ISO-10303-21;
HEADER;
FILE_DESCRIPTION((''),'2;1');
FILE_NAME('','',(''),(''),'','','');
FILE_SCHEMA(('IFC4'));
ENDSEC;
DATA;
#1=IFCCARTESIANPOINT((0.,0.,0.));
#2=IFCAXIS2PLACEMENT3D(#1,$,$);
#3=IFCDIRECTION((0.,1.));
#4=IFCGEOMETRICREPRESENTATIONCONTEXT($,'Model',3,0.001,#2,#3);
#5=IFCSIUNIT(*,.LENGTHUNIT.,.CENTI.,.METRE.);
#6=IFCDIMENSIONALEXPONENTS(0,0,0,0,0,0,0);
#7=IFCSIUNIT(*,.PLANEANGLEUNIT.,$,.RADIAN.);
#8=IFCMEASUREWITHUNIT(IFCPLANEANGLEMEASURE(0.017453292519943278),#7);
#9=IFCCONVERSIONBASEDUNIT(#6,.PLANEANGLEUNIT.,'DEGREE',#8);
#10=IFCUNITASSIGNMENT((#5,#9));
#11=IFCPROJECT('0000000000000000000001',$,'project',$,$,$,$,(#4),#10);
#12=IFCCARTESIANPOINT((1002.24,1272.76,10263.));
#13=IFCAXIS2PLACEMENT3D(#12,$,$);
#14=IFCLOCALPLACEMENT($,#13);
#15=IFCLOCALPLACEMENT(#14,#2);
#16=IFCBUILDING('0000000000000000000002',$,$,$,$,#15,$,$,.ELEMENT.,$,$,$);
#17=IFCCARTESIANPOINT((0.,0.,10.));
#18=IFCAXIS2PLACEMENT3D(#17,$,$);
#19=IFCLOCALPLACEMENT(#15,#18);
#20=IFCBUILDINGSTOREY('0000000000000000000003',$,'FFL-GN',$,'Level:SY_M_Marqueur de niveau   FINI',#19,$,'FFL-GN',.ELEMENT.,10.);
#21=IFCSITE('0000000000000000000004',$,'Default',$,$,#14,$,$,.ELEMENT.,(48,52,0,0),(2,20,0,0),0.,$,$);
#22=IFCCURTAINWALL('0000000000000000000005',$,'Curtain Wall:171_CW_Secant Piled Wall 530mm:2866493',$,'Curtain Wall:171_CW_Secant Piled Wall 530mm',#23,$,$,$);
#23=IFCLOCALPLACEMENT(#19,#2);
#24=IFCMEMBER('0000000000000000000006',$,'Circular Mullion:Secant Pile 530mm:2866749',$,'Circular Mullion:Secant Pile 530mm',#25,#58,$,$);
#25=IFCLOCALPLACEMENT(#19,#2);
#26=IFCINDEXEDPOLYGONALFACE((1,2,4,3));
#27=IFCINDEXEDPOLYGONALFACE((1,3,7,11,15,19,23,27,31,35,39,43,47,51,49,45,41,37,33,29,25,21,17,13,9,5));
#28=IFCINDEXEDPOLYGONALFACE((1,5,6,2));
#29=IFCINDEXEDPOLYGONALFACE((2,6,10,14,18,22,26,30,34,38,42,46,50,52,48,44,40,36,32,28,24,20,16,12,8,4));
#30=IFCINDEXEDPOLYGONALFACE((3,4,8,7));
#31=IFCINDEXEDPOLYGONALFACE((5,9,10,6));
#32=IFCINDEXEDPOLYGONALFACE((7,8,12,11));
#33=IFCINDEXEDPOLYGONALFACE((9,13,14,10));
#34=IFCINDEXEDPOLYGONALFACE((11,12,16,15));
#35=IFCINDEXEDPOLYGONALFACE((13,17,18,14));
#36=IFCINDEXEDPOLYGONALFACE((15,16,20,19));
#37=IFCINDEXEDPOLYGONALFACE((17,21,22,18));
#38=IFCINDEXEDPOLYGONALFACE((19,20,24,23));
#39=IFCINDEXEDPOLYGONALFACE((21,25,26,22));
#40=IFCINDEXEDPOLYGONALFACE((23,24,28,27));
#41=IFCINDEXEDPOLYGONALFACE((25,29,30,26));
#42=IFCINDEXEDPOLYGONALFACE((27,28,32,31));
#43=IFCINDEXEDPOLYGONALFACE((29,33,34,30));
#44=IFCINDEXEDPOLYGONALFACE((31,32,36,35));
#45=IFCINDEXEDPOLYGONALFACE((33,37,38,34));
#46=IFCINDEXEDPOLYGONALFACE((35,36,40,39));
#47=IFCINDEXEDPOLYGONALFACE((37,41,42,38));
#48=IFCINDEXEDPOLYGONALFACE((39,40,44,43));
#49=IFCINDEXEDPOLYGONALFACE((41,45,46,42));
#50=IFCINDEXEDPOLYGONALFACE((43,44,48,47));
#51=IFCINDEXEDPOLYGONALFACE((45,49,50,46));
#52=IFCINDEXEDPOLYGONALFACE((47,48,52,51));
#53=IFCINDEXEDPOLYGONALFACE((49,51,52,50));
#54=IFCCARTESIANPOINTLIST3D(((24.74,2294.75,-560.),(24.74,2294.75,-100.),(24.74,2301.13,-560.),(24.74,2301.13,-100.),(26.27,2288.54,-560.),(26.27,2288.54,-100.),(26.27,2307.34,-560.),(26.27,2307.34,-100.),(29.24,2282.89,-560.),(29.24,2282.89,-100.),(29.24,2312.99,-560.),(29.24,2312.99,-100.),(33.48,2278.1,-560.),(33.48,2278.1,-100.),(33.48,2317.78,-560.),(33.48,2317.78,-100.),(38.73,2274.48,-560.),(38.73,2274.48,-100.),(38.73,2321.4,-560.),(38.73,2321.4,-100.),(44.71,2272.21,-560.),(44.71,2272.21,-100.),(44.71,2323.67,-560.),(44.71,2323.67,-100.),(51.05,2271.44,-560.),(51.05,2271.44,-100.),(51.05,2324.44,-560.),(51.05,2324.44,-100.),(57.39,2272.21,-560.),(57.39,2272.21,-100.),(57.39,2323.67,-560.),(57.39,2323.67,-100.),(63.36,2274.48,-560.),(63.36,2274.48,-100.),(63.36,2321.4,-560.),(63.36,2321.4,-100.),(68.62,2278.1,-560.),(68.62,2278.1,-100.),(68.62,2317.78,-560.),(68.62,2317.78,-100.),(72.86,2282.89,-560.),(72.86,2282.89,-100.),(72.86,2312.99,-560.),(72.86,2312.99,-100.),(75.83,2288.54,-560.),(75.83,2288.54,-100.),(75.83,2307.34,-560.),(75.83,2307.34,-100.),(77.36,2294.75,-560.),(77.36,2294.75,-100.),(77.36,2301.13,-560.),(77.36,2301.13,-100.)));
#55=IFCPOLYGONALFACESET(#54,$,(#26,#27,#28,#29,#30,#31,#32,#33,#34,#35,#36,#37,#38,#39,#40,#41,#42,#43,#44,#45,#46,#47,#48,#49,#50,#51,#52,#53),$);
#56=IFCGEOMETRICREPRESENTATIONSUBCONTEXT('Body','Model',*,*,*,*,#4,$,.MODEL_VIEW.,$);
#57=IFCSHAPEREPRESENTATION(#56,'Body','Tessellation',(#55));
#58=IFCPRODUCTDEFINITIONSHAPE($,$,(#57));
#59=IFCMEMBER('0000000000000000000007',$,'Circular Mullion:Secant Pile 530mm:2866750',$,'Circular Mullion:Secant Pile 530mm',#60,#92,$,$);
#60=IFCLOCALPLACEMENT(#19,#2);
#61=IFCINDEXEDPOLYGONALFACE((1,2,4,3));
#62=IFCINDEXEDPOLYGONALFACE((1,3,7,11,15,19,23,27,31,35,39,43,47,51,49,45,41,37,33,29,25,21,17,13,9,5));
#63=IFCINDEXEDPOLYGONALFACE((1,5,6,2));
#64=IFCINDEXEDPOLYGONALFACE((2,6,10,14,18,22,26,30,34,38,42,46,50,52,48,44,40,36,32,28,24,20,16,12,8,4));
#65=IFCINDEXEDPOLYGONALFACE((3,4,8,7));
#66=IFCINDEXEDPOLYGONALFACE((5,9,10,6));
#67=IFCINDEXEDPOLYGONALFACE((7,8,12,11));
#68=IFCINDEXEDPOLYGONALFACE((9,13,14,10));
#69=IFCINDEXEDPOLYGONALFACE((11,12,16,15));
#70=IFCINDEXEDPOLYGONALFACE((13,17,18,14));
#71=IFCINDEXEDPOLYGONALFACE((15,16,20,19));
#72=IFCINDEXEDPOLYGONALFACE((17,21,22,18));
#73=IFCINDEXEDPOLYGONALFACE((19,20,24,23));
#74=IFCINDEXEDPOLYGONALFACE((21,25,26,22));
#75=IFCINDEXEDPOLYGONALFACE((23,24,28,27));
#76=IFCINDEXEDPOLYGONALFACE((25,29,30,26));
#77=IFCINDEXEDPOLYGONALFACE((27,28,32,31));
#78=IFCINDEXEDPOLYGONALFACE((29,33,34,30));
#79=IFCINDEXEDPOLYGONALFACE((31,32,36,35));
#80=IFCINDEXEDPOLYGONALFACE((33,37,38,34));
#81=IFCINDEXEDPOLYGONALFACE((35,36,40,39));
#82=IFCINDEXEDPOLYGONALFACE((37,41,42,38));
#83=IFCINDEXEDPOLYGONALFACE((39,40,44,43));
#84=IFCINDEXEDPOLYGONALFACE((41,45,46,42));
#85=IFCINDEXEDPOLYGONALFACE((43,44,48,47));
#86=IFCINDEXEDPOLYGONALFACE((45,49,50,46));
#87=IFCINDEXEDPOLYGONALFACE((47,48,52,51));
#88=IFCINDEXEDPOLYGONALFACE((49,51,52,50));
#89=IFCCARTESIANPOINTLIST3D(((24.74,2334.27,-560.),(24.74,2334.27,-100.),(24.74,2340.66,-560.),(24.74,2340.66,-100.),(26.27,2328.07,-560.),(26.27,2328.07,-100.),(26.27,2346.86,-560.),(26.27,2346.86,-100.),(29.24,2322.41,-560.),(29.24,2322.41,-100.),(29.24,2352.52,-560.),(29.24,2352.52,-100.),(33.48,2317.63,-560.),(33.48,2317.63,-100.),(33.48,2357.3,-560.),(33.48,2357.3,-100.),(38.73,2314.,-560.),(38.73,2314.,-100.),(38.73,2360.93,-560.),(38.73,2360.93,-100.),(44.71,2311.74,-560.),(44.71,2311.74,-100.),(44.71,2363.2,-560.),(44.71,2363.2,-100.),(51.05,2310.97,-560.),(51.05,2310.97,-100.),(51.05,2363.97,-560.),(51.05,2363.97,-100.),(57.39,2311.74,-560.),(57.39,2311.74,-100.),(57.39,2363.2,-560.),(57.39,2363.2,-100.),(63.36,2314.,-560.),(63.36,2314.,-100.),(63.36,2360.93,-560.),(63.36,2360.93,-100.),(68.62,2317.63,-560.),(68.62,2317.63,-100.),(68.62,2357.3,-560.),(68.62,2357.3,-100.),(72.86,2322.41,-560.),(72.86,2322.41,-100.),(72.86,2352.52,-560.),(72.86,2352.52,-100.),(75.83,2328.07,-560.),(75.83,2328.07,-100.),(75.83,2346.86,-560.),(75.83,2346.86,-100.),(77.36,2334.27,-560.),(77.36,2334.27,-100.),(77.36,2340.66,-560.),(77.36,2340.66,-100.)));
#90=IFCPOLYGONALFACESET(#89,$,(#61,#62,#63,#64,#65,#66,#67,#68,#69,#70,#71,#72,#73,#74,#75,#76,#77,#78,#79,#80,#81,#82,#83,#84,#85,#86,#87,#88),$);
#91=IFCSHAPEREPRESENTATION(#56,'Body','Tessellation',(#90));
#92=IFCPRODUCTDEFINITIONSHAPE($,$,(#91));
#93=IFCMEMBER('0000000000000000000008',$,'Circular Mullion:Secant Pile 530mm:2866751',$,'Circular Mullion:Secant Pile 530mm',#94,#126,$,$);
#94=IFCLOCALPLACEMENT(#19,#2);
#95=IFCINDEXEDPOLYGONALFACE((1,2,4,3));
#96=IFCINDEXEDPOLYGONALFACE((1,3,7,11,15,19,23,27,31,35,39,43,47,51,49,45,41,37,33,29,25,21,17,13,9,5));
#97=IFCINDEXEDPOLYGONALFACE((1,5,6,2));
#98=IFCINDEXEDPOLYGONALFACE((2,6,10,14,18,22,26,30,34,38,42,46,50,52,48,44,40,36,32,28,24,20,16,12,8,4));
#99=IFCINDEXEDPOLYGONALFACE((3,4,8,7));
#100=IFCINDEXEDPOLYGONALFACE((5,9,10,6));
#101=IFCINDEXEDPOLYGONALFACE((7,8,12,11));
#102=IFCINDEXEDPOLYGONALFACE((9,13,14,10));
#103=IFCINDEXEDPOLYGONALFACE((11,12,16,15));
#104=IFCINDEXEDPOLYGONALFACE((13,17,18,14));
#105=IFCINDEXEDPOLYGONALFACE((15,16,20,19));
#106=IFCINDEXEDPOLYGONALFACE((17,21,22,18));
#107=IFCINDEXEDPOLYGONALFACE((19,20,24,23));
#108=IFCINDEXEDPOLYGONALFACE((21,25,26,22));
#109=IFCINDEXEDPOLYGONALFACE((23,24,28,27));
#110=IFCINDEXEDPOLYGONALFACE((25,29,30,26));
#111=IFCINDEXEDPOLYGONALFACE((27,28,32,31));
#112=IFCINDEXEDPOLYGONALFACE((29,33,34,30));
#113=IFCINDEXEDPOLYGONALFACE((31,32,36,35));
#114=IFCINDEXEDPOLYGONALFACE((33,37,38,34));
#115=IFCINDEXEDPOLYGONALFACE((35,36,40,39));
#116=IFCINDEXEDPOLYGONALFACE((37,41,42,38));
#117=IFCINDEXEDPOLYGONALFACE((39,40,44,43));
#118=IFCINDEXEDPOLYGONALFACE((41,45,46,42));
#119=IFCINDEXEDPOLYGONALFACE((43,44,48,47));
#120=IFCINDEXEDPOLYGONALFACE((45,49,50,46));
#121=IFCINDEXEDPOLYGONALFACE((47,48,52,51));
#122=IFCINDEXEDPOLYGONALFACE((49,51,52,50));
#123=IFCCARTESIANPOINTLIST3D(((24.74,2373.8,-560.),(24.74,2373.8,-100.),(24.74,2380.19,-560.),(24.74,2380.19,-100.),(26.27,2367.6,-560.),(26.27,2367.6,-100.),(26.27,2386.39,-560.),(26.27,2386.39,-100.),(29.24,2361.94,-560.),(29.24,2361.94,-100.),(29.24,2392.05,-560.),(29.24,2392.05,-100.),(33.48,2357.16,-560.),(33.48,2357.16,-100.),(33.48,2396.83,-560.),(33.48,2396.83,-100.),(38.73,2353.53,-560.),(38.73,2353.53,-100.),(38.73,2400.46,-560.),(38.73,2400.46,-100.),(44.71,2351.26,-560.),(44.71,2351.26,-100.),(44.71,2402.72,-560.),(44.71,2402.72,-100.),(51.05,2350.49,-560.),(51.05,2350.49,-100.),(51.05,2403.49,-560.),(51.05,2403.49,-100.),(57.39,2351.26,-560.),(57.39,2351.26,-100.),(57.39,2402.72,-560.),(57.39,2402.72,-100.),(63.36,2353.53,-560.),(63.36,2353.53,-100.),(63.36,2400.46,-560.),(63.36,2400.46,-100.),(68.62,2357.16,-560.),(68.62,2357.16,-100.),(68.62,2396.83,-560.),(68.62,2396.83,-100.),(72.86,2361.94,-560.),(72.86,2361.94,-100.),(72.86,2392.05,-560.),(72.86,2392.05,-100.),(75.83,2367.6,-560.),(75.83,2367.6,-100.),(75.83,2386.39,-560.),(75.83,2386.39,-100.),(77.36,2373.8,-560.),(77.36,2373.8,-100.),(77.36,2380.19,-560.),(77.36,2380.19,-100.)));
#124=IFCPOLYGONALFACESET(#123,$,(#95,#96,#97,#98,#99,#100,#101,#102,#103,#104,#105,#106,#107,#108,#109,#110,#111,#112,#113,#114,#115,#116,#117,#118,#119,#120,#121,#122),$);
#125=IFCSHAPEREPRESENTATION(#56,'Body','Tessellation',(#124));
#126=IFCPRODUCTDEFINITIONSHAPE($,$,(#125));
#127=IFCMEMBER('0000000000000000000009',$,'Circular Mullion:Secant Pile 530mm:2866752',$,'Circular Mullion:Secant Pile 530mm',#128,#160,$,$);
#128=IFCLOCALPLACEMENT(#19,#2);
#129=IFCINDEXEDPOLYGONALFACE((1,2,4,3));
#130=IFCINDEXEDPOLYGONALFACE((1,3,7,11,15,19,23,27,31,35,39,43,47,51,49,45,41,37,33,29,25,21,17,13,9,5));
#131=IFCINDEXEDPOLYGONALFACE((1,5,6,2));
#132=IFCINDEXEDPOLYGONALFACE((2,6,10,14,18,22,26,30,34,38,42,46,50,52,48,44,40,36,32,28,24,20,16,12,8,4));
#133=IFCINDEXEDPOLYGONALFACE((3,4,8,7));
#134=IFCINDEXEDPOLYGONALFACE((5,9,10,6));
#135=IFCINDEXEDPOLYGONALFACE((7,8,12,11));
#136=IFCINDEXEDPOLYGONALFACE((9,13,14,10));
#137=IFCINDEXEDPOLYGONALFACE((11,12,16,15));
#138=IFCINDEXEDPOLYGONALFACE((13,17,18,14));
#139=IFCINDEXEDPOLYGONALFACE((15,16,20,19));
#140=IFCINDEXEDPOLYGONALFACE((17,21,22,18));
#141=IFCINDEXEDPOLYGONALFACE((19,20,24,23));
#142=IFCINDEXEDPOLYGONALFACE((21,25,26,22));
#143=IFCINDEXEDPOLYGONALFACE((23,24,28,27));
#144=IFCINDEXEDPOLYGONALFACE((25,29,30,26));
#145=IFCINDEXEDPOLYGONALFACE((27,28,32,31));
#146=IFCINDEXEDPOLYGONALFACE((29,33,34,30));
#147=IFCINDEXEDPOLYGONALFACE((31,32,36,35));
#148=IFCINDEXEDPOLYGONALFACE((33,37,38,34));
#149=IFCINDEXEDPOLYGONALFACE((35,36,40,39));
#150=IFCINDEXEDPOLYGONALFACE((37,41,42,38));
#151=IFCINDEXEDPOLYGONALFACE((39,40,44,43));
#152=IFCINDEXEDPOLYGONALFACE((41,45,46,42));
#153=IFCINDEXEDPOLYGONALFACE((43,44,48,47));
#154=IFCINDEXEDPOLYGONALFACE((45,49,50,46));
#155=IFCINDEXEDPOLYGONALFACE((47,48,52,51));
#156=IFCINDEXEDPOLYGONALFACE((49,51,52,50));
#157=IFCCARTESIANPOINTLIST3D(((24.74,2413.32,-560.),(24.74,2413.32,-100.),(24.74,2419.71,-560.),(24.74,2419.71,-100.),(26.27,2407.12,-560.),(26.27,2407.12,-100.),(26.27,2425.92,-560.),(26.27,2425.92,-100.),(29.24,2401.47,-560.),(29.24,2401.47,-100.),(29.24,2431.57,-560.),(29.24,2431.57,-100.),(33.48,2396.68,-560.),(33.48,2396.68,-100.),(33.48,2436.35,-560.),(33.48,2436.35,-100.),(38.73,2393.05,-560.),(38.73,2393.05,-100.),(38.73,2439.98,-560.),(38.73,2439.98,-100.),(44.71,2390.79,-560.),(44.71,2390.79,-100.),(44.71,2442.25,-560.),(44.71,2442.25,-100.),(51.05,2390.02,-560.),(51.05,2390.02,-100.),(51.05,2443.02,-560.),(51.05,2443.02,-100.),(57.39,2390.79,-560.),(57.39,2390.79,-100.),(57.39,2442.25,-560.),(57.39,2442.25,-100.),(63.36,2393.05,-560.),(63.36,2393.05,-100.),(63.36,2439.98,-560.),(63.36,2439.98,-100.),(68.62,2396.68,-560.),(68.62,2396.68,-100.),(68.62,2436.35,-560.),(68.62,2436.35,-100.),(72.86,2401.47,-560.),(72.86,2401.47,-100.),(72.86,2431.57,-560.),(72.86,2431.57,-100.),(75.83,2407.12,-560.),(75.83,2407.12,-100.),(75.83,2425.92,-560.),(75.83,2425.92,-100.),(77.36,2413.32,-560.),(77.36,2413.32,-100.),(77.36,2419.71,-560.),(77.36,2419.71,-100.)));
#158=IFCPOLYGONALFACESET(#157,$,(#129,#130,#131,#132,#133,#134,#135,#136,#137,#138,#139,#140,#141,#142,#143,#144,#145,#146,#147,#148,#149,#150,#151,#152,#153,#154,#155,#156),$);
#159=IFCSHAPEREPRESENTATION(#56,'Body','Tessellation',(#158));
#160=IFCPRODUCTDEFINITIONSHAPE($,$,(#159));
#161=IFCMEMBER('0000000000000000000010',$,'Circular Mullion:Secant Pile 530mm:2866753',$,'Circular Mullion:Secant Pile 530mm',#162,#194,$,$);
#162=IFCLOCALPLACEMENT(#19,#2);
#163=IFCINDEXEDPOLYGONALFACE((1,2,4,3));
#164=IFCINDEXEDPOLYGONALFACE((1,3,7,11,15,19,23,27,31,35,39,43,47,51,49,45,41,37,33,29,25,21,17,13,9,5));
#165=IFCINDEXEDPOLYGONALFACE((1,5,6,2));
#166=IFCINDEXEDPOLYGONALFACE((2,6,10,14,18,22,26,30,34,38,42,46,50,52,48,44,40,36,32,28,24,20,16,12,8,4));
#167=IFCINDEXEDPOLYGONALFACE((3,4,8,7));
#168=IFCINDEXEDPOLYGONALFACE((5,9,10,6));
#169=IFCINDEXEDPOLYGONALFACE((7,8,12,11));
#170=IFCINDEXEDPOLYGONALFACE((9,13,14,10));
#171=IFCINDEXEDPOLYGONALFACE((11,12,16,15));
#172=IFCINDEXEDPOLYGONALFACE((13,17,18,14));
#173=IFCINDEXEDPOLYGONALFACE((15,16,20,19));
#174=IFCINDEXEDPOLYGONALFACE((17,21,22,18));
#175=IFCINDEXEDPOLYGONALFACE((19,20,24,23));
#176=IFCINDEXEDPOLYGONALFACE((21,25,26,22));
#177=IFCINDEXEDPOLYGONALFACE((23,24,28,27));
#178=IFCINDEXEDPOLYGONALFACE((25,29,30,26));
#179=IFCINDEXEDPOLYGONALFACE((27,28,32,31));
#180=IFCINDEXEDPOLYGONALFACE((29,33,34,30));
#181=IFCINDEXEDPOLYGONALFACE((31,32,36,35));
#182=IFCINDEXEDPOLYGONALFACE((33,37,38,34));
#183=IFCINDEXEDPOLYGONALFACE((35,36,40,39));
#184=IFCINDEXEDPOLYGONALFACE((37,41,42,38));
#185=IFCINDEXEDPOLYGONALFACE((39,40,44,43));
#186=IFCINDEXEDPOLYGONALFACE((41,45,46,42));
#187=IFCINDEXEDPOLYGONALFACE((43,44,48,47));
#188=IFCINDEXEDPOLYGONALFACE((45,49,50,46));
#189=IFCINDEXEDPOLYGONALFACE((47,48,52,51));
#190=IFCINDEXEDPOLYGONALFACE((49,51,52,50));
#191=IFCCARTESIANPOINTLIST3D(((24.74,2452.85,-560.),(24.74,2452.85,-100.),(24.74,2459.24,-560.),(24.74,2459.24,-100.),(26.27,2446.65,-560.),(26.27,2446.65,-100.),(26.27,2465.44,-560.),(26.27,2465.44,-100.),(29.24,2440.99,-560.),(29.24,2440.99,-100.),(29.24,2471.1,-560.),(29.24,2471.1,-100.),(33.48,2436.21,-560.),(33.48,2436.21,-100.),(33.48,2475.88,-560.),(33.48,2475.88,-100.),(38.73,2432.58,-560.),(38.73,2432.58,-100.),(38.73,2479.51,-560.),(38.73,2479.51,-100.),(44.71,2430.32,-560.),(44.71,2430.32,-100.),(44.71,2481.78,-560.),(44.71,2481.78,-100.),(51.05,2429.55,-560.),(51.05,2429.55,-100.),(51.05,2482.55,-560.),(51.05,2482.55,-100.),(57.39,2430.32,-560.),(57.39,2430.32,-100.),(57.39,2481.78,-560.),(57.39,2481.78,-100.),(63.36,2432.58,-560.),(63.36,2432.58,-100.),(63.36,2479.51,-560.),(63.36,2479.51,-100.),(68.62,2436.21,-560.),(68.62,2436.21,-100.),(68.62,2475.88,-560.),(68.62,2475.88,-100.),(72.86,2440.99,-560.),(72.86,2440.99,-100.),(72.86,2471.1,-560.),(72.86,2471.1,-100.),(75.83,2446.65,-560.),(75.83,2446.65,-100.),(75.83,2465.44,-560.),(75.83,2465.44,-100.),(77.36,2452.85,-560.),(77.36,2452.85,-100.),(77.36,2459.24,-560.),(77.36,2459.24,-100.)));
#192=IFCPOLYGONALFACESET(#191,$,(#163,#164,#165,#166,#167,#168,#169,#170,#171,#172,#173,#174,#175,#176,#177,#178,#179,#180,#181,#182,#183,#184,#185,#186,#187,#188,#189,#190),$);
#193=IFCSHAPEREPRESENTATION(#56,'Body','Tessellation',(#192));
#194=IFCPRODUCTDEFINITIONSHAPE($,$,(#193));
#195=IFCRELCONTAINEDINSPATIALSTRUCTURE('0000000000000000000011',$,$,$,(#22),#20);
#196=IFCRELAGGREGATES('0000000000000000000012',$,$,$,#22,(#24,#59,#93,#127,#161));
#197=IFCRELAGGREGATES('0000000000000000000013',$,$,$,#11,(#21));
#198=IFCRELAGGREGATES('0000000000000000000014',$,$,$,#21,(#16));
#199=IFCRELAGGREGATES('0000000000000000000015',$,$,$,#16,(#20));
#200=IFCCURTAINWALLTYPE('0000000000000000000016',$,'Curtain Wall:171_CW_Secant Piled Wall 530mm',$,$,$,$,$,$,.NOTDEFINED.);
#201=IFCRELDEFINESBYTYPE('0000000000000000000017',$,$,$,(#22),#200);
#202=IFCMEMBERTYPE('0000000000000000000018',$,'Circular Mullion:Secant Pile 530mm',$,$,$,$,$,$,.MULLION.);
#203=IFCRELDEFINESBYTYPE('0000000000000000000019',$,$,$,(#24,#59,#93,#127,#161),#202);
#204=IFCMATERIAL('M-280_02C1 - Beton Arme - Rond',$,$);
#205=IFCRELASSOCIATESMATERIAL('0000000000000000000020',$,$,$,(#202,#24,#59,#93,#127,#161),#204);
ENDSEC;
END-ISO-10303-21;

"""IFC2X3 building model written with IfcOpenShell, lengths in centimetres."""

from ifc_helpers import new_model, entity, si_unit, converted_unit, direction, frame, frame_2d, origin, place, context, subcontext, project, spatial, circle, extrude, source, transform, mapped, material, type_object, type_shapes, element, aggregate, save


model = new_model("IFC2X3")

# Units and contexts
model_context = context("Model", 3, precision=0.001, world=origin(), true_north=direction((0.0, 1.0)))
body_context = subcontext(model_context, "Body", "Model", "MODEL_VIEW")
ifc_project = project(units=[si_unit("LENGTHUNIT", "METRE", prefix="CENTI"), converted_unit("PLANEANGLEUNIT", "DEGREE", entity("IfcPlaneAngleMeasure", 0.017453292519943278), si_unit("PLANEANGLEUNIT", "RADIAN"), dimensions=[0, 0, 0, 0, 0, 0, 0])], contexts=[model_context])

# Site, building, storey
site_placement = place(None, frame((1002.24, 1272.76, 10263.0)))
site = spatial("IfcSite", under=ifc_project, at=site_placement, Name="Default", CompositionType="ELEMENT", RefLatitude=(48, 52, 0, 0), RefLongitude=(2, 20, 0, 0), RefElevation=0.0)
building_placement = place(site_placement, origin())
building = spatial("IfcBuilding", under=site, at=building_placement, CompositionType="ELEMENT")
storey_placement = place(building_placement, frame((0.0, 0.0, 10.0)))
storey = spatial("IfcBuildingStorey", under=building, at=storey_placement, Name="FFL-GN", ObjectType="Level:SY_M_Marqueur de niveau   FINI", LongName="FFL-GN", CompositionType="ELEMENT", Elevation=10.0)

# Curtain wall, members
curtain_wall_type = type_object("IfcCurtainWallType", Name="Curtain Wall:171_CW_Secant Piled Wall 530mm", PredefinedType="NOTDEFINED")
curtain_wall_placement = place(storey_placement, frame((0.0, 0.0, -10.0)))
curtain_wall = element("IfcCurtainWall", 1, at=curtain_wall_placement, inside=storey, type_object=curtain_wall_type, Name="Curtain Wall:171_CW_Secant Piled Wall 530mm:2866493", ObjectType="Curtain Wall:171_CW_Secant Piled Wall 530mm")
ifc_material_1 = material(Name="M-280_02C1 - Beton Arme - Rond")
member_type = type_object("IfcMemberType", Name="Circular Mullion:Secant Pile 530mm", PredefinedType="MULLION", material=ifc_material_1)
shared_shape = source(origin(), body_context, "Body", "SweptSolid", [
    extrude(circle(Radius=26.5, at=frame_2d((0.0, 0.0), x_axis=(1.0, 0.0))), frame((0.0, 0.0, -460.0)), (0.0, 0.0, 1.0), 460.0),
])
type_shapes(member_type, [shared_shape])
member_1_placement = place(curtain_wall_placement, frame((51.05, 2297.94, -550.0), z_axis=(0.0, 0.0, -1.0), x_axis=(0.0, 1.0, 0.0)))
member_1 = element("IfcMember", 2, at=member_1_placement, type_object=member_type, material=ifc_material_1, Name="Circular Mullion:Secant Pile 530mm:2866749", ObjectType="Circular Mullion:Secant Pile 530mm", context=body_context, shape_type="MappedRepresentation", body=[
    mapped(shared_shape, transform((0.0, 0.0, 0.0), scale=1.0)),
])
member_2_placement = place(curtain_wall_placement, frame((51.05, 2337.47, -550.0), z_axis=(0.0, 0.0, -1.0), x_axis=(0.0, 1.0, 0.0)))
member_2 = element("IfcMember", 3, at=member_2_placement, type_object=member_type, material=ifc_material_1, Name="Circular Mullion:Secant Pile 530mm:2866750", ObjectType="Circular Mullion:Secant Pile 530mm", context=body_context, shape_type="MappedRepresentation", body=[
    mapped(shared_shape, transform((0.0, 0.0, 0.0), scale=1.0)),
])
member_3_placement = place(curtain_wall_placement, frame((51.05, 2376.99, -550.0), z_axis=(0.0, 0.0, -1.0), x_axis=(0.0, 1.0, 0.0)))
member_3 = element("IfcMember", 4, at=member_3_placement, type_object=member_type, material=ifc_material_1, Name="Circular Mullion:Secant Pile 530mm:2866751", ObjectType="Circular Mullion:Secant Pile 530mm", context=body_context, shape_type="MappedRepresentation", body=[
    mapped(shared_shape, transform((0.0, 0.0, 0.0), scale=1.0)),
])
member_4_placement = place(curtain_wall_placement, frame((51.05, 2416.52, -550.0), z_axis=(0.0, 0.0, -1.0), x_axis=(0.0, 1.0, 0.0)))
member_4 = element("IfcMember", 5, at=member_4_placement, type_object=member_type, material=ifc_material_1, Name="Circular Mullion:Secant Pile 530mm:2866752", ObjectType="Circular Mullion:Secant Pile 530mm", context=body_context, shape_type="MappedRepresentation", body=[
    mapped(shared_shape, transform((0.0, 0.0, 0.0), scale=1.0)),
])
member_5_placement = place(curtain_wall_placement, frame((51.05, 2456.05, -550.0), z_axis=(0.0, 0.0, -1.0), x_axis=(0.0, 1.0, 0.0)))
member_5 = element("IfcMember", 6, at=member_5_placement, type_object=member_type, material=ifc_material_1, Name="Circular Mullion:Secant Pile 530mm:2866753", ObjectType="Circular Mullion:Secant Pile 530mm", context=body_context, shape_type="MappedRepresentation", body=[
    mapped(shared_shape, transform((0.0, 0.0, 0.0), scale=1.0)),
])
aggregate(curtain_wall, [member_1, member_2, member_3, member_4, member_5])

save(model, "model.ifc")
